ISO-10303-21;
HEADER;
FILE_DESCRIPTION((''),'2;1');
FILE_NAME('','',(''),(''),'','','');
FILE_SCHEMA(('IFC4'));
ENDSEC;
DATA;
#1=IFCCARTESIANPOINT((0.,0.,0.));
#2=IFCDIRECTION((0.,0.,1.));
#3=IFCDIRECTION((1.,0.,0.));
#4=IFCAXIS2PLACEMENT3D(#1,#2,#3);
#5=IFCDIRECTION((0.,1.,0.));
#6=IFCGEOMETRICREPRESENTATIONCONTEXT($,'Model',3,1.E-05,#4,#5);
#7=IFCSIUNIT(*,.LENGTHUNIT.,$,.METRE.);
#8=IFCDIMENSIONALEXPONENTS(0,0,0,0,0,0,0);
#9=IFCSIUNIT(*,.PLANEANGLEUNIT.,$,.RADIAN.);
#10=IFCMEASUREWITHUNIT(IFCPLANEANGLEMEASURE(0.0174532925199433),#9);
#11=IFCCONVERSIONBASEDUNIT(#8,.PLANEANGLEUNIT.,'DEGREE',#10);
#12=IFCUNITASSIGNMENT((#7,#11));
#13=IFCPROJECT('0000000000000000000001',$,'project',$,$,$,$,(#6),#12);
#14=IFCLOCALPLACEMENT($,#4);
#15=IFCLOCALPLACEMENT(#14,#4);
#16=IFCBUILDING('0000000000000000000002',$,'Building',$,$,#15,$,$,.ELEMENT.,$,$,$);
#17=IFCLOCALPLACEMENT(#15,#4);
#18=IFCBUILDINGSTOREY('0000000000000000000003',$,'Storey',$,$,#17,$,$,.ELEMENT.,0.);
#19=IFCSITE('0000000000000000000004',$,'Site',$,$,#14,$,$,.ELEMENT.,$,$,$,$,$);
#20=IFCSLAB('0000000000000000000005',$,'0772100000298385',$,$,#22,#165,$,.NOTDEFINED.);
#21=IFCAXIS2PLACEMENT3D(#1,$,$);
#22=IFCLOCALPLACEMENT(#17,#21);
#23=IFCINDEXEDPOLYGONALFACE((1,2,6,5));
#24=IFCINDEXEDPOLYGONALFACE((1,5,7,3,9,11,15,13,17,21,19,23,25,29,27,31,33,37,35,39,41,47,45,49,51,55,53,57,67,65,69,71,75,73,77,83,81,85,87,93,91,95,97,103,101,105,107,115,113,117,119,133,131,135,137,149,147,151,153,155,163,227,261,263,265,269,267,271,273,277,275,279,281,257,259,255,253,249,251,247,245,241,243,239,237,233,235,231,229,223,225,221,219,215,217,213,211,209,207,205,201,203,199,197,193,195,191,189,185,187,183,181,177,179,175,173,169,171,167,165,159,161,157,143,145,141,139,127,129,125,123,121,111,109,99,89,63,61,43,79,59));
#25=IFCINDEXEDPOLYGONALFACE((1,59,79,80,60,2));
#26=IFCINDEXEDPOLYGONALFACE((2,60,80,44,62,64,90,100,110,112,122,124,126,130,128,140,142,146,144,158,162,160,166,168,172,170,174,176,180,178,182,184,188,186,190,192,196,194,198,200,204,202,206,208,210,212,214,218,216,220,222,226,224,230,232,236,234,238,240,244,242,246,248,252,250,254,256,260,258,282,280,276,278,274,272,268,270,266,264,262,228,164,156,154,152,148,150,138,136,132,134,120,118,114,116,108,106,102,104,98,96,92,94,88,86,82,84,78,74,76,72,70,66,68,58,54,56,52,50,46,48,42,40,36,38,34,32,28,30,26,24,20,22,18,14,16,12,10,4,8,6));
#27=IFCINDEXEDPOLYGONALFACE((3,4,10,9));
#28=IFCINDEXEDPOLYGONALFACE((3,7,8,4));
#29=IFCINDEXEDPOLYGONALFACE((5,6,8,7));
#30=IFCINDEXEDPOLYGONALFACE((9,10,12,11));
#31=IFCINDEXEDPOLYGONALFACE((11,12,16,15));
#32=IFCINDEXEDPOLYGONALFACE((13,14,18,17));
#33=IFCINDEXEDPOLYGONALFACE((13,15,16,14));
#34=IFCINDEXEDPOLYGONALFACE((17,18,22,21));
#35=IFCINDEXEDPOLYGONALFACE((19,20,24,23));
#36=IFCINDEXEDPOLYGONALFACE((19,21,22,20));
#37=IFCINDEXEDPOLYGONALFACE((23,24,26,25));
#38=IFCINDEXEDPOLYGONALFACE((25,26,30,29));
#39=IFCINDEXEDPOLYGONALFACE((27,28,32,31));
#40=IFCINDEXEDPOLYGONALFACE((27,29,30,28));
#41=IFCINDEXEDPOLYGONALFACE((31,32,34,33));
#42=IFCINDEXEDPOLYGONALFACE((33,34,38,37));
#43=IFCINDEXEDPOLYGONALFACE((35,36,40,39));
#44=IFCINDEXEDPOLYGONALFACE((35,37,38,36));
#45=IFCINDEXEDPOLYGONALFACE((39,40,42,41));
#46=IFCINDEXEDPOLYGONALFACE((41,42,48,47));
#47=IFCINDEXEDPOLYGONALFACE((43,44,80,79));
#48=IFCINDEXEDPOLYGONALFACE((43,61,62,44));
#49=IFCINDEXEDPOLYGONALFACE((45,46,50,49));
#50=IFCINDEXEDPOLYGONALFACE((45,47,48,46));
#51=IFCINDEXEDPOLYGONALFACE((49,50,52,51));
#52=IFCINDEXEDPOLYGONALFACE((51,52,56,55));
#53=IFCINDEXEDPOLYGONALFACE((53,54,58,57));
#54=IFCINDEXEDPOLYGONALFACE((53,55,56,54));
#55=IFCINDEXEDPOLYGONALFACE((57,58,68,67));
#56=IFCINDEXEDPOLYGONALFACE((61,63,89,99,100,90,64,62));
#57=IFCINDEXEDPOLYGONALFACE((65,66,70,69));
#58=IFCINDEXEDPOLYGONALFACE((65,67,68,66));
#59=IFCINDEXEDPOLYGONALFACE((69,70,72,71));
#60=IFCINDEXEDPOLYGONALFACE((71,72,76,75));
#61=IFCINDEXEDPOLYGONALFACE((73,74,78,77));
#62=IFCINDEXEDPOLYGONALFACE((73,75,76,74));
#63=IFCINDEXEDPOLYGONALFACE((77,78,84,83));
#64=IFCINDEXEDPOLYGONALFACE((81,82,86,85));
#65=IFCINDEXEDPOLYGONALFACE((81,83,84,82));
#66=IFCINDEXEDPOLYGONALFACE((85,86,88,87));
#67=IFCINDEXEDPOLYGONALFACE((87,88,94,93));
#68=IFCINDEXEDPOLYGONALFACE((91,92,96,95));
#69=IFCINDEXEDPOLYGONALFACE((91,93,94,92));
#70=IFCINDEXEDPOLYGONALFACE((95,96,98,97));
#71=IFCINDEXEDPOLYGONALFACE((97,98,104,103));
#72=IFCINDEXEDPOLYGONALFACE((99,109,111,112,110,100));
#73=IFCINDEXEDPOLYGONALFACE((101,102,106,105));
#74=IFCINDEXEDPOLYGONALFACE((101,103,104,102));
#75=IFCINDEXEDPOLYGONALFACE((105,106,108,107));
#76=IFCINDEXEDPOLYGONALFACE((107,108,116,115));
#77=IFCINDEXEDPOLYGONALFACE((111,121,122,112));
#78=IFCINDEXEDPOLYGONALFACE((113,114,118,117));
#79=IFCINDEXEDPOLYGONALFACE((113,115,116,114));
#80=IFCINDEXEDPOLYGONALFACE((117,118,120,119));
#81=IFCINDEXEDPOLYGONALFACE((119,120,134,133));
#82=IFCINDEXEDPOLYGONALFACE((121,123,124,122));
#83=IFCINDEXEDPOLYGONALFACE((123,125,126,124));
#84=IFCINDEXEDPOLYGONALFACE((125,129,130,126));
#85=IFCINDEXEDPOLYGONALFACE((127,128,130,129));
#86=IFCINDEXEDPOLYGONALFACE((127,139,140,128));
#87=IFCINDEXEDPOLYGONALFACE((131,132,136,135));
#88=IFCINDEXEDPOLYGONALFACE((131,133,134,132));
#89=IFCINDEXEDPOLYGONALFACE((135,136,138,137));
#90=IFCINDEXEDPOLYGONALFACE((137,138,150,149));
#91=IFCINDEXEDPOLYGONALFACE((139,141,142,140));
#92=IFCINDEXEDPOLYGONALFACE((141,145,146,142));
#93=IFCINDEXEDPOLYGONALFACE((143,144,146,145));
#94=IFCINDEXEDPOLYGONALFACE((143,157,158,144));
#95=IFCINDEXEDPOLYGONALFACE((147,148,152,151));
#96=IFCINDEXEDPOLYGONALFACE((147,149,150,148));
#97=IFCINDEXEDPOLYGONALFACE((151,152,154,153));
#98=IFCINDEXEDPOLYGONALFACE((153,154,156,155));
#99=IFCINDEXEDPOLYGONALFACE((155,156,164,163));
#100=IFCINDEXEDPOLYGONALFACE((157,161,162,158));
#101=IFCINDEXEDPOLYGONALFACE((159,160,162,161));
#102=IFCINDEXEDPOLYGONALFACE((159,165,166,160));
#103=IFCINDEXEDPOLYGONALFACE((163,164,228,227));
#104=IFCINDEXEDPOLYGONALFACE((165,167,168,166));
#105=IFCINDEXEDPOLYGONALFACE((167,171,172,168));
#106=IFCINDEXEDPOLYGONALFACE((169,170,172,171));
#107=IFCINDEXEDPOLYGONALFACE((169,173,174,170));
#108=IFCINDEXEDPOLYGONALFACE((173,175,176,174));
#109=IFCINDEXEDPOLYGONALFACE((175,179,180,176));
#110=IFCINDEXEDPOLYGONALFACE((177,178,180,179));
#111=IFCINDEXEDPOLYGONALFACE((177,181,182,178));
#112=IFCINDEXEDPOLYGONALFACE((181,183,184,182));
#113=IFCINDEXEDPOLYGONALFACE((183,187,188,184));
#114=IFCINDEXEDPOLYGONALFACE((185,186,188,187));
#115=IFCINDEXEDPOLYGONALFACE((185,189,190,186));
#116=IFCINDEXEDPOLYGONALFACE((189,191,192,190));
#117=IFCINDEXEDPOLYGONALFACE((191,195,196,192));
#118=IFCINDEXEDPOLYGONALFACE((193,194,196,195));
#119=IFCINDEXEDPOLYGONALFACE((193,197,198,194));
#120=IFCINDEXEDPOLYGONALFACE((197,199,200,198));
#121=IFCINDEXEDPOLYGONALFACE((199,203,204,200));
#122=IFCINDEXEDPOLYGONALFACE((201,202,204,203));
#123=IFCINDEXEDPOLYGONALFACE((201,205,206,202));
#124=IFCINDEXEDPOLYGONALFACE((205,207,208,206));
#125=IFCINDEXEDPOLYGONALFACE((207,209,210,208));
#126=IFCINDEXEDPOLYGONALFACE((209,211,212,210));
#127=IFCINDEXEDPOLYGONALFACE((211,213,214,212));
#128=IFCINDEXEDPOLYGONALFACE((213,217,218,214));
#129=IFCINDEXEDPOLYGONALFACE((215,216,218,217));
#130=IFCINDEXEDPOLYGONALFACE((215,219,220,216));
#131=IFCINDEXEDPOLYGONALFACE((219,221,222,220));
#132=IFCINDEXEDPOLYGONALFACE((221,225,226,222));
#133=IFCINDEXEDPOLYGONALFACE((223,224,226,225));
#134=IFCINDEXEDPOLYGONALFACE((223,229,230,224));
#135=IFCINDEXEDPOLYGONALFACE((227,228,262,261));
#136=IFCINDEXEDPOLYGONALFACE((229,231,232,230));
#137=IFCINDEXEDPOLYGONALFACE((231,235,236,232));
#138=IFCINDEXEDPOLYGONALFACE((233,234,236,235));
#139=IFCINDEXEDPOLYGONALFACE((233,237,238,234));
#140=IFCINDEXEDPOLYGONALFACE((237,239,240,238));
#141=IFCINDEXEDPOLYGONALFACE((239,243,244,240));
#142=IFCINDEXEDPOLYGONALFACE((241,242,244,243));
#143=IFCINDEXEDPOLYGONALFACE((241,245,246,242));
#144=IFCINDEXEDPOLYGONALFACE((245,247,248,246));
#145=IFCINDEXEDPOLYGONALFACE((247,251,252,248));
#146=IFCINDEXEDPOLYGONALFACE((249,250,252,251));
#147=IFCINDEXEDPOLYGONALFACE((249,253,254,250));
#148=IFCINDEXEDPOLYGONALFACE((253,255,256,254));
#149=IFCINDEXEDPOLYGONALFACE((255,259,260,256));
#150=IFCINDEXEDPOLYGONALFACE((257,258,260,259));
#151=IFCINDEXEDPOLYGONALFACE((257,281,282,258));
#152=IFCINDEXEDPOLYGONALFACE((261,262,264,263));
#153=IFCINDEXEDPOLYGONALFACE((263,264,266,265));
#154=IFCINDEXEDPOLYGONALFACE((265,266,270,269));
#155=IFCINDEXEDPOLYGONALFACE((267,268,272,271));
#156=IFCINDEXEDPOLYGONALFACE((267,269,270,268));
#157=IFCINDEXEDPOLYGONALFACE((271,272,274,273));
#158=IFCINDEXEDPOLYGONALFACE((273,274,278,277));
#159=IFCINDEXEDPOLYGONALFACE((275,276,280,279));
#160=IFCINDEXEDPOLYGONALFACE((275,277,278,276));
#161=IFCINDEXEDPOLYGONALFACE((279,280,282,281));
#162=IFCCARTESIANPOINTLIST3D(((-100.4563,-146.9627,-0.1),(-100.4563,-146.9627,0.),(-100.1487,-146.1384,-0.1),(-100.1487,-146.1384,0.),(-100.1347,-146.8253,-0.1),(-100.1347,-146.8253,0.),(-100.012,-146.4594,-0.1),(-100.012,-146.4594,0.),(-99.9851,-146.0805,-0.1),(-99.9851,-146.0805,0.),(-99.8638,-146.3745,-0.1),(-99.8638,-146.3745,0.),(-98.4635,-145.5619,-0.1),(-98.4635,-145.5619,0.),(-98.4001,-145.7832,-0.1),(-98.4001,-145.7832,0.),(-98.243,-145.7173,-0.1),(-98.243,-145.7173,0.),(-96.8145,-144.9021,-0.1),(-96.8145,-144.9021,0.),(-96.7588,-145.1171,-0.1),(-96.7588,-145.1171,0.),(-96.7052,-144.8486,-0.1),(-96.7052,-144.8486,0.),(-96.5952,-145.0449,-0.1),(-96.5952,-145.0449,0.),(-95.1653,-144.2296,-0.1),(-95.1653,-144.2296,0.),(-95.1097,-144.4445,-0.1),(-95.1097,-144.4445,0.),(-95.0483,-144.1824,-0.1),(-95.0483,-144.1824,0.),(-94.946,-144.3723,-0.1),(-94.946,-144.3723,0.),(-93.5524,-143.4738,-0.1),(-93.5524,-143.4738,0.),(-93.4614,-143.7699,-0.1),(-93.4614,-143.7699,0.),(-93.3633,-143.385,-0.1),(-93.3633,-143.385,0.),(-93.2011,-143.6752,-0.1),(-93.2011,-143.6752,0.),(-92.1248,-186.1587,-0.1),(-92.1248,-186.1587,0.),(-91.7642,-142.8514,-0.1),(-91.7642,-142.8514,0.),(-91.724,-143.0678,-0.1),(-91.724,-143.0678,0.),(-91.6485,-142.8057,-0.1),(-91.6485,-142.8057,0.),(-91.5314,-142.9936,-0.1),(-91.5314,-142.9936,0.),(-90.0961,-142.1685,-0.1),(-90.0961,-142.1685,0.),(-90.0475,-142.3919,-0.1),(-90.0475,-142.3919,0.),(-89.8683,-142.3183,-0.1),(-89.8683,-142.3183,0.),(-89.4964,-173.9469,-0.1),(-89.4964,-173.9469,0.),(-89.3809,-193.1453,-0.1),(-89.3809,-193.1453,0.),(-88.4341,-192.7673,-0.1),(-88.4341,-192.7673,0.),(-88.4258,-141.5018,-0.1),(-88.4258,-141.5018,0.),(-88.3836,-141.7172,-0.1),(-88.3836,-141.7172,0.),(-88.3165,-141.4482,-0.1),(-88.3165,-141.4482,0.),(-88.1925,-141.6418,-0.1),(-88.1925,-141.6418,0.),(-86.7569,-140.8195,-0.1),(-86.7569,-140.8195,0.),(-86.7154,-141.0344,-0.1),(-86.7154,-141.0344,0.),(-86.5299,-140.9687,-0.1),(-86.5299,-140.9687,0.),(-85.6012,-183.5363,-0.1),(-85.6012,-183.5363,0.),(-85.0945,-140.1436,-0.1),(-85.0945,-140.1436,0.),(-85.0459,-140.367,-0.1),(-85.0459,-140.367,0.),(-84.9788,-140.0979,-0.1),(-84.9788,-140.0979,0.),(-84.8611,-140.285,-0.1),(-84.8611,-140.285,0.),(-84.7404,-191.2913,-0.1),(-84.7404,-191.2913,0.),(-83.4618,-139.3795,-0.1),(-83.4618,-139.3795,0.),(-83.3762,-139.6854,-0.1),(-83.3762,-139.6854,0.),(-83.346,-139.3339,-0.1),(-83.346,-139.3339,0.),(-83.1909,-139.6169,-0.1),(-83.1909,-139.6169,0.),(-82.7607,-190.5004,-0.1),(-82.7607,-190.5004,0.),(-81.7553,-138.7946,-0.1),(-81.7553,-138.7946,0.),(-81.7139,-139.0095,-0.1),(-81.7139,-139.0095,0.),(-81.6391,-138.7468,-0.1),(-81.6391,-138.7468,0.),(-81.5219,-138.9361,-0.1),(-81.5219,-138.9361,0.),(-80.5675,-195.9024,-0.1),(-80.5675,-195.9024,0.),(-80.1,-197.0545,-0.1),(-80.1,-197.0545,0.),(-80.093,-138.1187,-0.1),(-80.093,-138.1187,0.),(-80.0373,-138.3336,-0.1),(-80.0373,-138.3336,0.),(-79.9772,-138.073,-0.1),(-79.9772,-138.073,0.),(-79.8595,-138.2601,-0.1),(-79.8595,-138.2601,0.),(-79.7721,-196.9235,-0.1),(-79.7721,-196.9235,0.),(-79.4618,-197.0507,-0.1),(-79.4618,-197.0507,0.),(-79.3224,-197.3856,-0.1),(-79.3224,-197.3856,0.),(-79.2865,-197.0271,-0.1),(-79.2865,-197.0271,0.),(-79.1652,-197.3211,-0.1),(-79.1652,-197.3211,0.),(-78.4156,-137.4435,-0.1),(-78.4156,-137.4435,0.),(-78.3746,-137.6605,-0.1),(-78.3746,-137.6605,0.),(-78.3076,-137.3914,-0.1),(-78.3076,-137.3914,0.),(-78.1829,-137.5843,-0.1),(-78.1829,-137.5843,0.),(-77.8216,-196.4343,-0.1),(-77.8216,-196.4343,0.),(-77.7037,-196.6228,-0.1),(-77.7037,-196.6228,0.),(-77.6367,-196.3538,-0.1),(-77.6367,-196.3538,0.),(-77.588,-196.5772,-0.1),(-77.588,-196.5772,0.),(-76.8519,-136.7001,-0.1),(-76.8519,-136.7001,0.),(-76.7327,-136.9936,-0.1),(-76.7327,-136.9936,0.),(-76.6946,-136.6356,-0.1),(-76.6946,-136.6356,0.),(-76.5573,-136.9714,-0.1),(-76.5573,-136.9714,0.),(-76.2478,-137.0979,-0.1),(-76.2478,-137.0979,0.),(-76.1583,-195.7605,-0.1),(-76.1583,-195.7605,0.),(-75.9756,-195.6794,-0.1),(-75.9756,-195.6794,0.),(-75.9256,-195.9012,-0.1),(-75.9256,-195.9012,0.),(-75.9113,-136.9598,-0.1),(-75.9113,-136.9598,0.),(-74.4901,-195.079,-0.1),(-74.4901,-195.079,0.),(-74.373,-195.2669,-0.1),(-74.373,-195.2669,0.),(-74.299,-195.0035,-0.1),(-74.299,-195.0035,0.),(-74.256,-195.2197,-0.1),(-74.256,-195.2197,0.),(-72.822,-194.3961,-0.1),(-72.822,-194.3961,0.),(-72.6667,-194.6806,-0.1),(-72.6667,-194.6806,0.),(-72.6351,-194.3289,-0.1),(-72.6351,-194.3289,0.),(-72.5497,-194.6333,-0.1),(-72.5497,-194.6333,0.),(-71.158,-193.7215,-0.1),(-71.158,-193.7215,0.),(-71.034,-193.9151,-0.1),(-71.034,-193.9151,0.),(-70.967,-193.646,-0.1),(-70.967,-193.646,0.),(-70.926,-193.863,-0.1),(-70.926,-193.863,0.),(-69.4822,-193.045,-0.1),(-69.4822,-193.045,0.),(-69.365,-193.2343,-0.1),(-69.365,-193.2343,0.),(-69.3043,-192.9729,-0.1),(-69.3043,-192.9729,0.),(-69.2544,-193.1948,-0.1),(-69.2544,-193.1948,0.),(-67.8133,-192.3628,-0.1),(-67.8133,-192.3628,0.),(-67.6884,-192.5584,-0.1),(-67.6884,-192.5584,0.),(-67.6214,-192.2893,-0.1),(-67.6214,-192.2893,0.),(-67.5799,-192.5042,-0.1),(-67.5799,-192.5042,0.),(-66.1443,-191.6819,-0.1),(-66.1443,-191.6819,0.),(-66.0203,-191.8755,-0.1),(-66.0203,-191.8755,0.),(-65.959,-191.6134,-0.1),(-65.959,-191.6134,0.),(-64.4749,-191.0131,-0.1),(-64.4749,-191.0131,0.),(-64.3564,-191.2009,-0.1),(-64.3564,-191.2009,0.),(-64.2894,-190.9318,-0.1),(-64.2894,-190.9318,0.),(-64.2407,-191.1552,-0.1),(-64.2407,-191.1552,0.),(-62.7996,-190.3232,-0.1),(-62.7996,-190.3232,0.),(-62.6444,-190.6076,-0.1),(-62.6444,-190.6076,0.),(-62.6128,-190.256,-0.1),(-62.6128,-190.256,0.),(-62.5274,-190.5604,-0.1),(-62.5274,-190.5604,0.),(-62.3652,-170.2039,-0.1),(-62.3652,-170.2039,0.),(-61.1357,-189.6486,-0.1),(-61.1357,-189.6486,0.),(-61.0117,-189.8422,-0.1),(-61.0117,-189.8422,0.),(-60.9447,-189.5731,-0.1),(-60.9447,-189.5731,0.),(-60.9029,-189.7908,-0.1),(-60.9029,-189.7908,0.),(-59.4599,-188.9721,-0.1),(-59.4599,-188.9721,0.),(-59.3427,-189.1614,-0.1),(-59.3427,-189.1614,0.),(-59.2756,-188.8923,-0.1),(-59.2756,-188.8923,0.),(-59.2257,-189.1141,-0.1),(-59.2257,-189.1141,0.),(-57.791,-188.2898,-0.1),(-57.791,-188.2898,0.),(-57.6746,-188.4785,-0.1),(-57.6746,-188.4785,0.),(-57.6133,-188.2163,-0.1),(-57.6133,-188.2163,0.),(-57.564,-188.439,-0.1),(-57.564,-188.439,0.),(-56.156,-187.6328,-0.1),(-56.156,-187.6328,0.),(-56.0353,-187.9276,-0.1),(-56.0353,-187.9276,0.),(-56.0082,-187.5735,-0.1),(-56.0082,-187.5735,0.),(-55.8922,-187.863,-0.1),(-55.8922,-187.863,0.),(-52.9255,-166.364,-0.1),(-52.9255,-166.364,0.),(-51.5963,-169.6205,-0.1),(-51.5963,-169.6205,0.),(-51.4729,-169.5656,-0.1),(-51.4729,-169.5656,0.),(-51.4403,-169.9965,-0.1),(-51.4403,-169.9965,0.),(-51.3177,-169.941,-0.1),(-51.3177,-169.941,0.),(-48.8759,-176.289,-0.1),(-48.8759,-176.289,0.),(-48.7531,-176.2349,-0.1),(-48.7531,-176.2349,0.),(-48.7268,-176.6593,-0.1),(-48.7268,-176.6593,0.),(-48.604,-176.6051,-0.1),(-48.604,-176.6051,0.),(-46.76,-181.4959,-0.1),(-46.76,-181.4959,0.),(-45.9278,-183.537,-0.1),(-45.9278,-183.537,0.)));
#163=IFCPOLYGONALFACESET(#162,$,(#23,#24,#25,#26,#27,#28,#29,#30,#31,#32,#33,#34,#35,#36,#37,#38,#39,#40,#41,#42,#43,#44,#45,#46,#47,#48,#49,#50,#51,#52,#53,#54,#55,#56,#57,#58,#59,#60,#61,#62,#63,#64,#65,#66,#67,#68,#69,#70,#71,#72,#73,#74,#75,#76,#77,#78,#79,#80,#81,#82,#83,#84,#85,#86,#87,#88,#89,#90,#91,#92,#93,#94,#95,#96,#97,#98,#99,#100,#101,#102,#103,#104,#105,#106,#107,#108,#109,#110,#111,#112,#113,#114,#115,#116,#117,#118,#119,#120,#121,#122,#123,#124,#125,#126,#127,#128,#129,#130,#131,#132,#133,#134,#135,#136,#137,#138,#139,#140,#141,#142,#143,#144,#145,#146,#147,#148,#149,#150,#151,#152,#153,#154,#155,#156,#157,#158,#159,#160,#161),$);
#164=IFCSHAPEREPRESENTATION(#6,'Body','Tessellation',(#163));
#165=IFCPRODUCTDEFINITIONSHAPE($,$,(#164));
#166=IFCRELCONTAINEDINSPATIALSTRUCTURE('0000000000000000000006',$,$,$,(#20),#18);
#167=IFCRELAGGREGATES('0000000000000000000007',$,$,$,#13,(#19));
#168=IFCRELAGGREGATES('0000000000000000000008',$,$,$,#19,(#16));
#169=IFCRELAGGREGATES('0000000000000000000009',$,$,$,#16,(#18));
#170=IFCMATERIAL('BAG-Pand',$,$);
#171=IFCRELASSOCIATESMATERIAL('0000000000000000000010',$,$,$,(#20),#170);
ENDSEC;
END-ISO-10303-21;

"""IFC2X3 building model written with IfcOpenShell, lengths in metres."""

from ifc_helpers import new_model, entity, si_unit, converted_unit, direction, frame, origin_with_axes, place, context, project, spatial, polyline, outline, extrude, material, element, save


model = new_model("IFC2X3")

# Units and contexts
model_context = context("Model", 3, precision=1e-05, world=origin_with_axes(), true_north=direction((0.0, 1.0, 0.0)))
ifc_project = project(units=[si_unit("LENGTHUNIT", "METRE"), converted_unit("PLANEANGLEUNIT", "DEGREE", entity("IfcPlaneAngleMeasure", 0.0174532925199433), si_unit("PLANEANGLEUNIT", "RADIAN"), dimensions=[0, 0, 0, 0, 0, 0, 0])], contexts=[model_context])

# Site, building, storey
site_placement = place(None, origin_with_axes())
site = spatial("IfcSite", under=ifc_project, at=site_placement, Name="Site", CompositionType="ELEMENT")
building_placement = place(site_placement, origin_with_axes())
building = spatial("IfcBuilding", under=site, at=building_placement, Name="Building", CompositionType="ELEMENT")
storey_placement = place(building_placement, origin_with_axes())
storey = spatial("IfcBuildingStorey", under=building, at=storey_placement, Name="Storey", CompositionType="ELEMENT", Elevation=0.0)

# Slab
ifc_material = material(Name="BAG-Pand")
slab_1_placement = place(storey_placement, frame((0.0, 0.0, -0.1), z_axis=(0.0, 0.0, 1.0), x_axis=(1.0, 0.0, 0.0)))
element("IfcSlab", 1, at=slab_1_placement, inside=storey, material=ifc_material, Name="0772100000298385", PredefinedType="NOTDEFINED", context=model_context, shape_type="SweptSolid", body=[
    extrude(outline(polyline([(-88.4341, -192.7673), (-89.3809, -193.1453), (-92.1248, -186.1587), (-85.6012, -183.5363), (-89.4964, -173.9469), (-100.4563, -146.9627), (-100.1347, -146.8253), (-100.012, -146.4594), (-100.1487, -146.1384), (-99.9851, -146.0805), (-99.8638, -146.3745), (-98.4001, -145.7832), (-98.4635, -145.5619), (-98.243, -145.7173), (-96.7588, -145.1171), (-96.8145, -144.9021), (-96.7052, -144.8486), (-96.5952, -145.0449), (-95.1097, -144.4445), (-95.1653, -144.2296), (-95.0483, -144.1824), (-94.946, -144.3723), (-93.4614, -143.7699), (-93.5524, -143.4738), (-93.3633, -143.385), (-93.2011, -143.6752), (-91.724, -143.0678), (-91.7642, -142.8514), (-91.6485, -142.8057), (-91.5314, -142.9936), (-90.0475, -142.3919), (-90.0961, -142.1685), (-89.8683, -142.3183), (-88.3836, -141.7172), (-88.4258, -141.5018), (-88.3165, -141.4482), (-88.1925, -141.6418), (-86.7154, -141.0344), (-86.7569, -140.8195), (-86.5299, -140.9687), (-85.0459, -140.367), (-85.0945, -140.1436), (-84.9788, -140.0979), (-84.8611, -140.285), (-83.3762, -139.6854), (-83.4618, -139.3795), (-83.346, -139.3339), (-83.1909, -139.6169), (-81.7139, -139.0095), (-81.7553, -138.7946), (-81.6391, -138.7468), (-81.5219, -138.9361), (-80.0373, -138.3336), (-80.093, -138.1187), (-79.9772, -138.073), (-79.8595, -138.2601), (-78.3746, -137.6605), (-78.4156, -137.4435), (-78.3076, -137.3914), (-78.1829, -137.5843), (-76.7327, -136.9936), (-76.8519, -136.7001), (-76.6946, -136.6356), (-76.5573, -136.9714), (-76.2478, -137.0979), (-75.9113, -136.9598), (-62.3652, -170.2039), (-52.9255, -166.364), (-51.5963, -169.6205), (-51.4729, -169.5656), (-51.3177, -169.941), (-51.4403, -169.9965), (-48.8759, -176.289), (-48.7531, -176.2349), (-48.604, -176.6051), (-48.7268, -176.6593), (-46.76, -181.4959), (-45.9278, -183.537), (-56.0082, -187.5735), (-55.8922, -187.863), (-56.0353, -187.9276), (-56.156, -187.6328), (-57.6133, -188.2163), (-57.564, -188.439), (-57.6746, -188.4785), (-57.791, -188.2898), (-59.2756, -188.8923), (-59.2257, -189.1141), (-59.3427, -189.1614), (-59.4599, -188.9721), (-60.9447, -189.5731), (-60.9029, -189.7908), (-61.0117, -189.8422), (-61.1357, -189.6486), (-62.6128, -190.256), (-62.5274, -190.5604), (-62.6444, -190.6076), (-62.7996, -190.3232), (-64.2894, -190.9318), (-64.2407, -191.1552), (-64.3564, -191.2009), (-64.4749, -191.0131), (-65.959, -191.6134), (-66.0203, -191.8755), (-66.1443, -191.6819), (-67.6214, -192.2893), (-67.5799, -192.5042), (-67.6884, -192.5584), (-67.8133, -192.3628), (-69.3043, -192.9729), (-69.2544, -193.1948), (-69.365, -193.2343), (-69.4822, -193.045), (-70.967, -193.646), (-70.926, -193.863), (-71.034, -193.9151), (-71.158, -193.7215), (-72.6351, -194.3289), (-72.5497, -194.6333), (-72.6667, -194.6806), (-72.822, -194.3961), (-74.299, -195.0035), (-74.256, -195.2197), (-74.373, -195.2669), (-74.4901, -195.079), (-75.9756, -195.6794), (-75.9256, -195.9012), (-76.1583, -195.7605), (-77.6367, -196.3538), (-77.588, -196.5772), (-77.7037, -196.6228), (-77.8216, -196.4343), (-79.2865, -197.0271), (-79.1652, -197.3211), (-79.3224, -197.3856), (-79.4618, -197.0507), (-79.7721, -196.9235), (-80.1, -197.0545), (-80.5675, -195.9024), (-82.7607, -190.5004), (-84.7404, -191.2913), (-88.4341, -192.7673)])), origin_with_axes(), (0.0, 0.0, 1.0), 0.1),
])

save(model, "model.ifc")
